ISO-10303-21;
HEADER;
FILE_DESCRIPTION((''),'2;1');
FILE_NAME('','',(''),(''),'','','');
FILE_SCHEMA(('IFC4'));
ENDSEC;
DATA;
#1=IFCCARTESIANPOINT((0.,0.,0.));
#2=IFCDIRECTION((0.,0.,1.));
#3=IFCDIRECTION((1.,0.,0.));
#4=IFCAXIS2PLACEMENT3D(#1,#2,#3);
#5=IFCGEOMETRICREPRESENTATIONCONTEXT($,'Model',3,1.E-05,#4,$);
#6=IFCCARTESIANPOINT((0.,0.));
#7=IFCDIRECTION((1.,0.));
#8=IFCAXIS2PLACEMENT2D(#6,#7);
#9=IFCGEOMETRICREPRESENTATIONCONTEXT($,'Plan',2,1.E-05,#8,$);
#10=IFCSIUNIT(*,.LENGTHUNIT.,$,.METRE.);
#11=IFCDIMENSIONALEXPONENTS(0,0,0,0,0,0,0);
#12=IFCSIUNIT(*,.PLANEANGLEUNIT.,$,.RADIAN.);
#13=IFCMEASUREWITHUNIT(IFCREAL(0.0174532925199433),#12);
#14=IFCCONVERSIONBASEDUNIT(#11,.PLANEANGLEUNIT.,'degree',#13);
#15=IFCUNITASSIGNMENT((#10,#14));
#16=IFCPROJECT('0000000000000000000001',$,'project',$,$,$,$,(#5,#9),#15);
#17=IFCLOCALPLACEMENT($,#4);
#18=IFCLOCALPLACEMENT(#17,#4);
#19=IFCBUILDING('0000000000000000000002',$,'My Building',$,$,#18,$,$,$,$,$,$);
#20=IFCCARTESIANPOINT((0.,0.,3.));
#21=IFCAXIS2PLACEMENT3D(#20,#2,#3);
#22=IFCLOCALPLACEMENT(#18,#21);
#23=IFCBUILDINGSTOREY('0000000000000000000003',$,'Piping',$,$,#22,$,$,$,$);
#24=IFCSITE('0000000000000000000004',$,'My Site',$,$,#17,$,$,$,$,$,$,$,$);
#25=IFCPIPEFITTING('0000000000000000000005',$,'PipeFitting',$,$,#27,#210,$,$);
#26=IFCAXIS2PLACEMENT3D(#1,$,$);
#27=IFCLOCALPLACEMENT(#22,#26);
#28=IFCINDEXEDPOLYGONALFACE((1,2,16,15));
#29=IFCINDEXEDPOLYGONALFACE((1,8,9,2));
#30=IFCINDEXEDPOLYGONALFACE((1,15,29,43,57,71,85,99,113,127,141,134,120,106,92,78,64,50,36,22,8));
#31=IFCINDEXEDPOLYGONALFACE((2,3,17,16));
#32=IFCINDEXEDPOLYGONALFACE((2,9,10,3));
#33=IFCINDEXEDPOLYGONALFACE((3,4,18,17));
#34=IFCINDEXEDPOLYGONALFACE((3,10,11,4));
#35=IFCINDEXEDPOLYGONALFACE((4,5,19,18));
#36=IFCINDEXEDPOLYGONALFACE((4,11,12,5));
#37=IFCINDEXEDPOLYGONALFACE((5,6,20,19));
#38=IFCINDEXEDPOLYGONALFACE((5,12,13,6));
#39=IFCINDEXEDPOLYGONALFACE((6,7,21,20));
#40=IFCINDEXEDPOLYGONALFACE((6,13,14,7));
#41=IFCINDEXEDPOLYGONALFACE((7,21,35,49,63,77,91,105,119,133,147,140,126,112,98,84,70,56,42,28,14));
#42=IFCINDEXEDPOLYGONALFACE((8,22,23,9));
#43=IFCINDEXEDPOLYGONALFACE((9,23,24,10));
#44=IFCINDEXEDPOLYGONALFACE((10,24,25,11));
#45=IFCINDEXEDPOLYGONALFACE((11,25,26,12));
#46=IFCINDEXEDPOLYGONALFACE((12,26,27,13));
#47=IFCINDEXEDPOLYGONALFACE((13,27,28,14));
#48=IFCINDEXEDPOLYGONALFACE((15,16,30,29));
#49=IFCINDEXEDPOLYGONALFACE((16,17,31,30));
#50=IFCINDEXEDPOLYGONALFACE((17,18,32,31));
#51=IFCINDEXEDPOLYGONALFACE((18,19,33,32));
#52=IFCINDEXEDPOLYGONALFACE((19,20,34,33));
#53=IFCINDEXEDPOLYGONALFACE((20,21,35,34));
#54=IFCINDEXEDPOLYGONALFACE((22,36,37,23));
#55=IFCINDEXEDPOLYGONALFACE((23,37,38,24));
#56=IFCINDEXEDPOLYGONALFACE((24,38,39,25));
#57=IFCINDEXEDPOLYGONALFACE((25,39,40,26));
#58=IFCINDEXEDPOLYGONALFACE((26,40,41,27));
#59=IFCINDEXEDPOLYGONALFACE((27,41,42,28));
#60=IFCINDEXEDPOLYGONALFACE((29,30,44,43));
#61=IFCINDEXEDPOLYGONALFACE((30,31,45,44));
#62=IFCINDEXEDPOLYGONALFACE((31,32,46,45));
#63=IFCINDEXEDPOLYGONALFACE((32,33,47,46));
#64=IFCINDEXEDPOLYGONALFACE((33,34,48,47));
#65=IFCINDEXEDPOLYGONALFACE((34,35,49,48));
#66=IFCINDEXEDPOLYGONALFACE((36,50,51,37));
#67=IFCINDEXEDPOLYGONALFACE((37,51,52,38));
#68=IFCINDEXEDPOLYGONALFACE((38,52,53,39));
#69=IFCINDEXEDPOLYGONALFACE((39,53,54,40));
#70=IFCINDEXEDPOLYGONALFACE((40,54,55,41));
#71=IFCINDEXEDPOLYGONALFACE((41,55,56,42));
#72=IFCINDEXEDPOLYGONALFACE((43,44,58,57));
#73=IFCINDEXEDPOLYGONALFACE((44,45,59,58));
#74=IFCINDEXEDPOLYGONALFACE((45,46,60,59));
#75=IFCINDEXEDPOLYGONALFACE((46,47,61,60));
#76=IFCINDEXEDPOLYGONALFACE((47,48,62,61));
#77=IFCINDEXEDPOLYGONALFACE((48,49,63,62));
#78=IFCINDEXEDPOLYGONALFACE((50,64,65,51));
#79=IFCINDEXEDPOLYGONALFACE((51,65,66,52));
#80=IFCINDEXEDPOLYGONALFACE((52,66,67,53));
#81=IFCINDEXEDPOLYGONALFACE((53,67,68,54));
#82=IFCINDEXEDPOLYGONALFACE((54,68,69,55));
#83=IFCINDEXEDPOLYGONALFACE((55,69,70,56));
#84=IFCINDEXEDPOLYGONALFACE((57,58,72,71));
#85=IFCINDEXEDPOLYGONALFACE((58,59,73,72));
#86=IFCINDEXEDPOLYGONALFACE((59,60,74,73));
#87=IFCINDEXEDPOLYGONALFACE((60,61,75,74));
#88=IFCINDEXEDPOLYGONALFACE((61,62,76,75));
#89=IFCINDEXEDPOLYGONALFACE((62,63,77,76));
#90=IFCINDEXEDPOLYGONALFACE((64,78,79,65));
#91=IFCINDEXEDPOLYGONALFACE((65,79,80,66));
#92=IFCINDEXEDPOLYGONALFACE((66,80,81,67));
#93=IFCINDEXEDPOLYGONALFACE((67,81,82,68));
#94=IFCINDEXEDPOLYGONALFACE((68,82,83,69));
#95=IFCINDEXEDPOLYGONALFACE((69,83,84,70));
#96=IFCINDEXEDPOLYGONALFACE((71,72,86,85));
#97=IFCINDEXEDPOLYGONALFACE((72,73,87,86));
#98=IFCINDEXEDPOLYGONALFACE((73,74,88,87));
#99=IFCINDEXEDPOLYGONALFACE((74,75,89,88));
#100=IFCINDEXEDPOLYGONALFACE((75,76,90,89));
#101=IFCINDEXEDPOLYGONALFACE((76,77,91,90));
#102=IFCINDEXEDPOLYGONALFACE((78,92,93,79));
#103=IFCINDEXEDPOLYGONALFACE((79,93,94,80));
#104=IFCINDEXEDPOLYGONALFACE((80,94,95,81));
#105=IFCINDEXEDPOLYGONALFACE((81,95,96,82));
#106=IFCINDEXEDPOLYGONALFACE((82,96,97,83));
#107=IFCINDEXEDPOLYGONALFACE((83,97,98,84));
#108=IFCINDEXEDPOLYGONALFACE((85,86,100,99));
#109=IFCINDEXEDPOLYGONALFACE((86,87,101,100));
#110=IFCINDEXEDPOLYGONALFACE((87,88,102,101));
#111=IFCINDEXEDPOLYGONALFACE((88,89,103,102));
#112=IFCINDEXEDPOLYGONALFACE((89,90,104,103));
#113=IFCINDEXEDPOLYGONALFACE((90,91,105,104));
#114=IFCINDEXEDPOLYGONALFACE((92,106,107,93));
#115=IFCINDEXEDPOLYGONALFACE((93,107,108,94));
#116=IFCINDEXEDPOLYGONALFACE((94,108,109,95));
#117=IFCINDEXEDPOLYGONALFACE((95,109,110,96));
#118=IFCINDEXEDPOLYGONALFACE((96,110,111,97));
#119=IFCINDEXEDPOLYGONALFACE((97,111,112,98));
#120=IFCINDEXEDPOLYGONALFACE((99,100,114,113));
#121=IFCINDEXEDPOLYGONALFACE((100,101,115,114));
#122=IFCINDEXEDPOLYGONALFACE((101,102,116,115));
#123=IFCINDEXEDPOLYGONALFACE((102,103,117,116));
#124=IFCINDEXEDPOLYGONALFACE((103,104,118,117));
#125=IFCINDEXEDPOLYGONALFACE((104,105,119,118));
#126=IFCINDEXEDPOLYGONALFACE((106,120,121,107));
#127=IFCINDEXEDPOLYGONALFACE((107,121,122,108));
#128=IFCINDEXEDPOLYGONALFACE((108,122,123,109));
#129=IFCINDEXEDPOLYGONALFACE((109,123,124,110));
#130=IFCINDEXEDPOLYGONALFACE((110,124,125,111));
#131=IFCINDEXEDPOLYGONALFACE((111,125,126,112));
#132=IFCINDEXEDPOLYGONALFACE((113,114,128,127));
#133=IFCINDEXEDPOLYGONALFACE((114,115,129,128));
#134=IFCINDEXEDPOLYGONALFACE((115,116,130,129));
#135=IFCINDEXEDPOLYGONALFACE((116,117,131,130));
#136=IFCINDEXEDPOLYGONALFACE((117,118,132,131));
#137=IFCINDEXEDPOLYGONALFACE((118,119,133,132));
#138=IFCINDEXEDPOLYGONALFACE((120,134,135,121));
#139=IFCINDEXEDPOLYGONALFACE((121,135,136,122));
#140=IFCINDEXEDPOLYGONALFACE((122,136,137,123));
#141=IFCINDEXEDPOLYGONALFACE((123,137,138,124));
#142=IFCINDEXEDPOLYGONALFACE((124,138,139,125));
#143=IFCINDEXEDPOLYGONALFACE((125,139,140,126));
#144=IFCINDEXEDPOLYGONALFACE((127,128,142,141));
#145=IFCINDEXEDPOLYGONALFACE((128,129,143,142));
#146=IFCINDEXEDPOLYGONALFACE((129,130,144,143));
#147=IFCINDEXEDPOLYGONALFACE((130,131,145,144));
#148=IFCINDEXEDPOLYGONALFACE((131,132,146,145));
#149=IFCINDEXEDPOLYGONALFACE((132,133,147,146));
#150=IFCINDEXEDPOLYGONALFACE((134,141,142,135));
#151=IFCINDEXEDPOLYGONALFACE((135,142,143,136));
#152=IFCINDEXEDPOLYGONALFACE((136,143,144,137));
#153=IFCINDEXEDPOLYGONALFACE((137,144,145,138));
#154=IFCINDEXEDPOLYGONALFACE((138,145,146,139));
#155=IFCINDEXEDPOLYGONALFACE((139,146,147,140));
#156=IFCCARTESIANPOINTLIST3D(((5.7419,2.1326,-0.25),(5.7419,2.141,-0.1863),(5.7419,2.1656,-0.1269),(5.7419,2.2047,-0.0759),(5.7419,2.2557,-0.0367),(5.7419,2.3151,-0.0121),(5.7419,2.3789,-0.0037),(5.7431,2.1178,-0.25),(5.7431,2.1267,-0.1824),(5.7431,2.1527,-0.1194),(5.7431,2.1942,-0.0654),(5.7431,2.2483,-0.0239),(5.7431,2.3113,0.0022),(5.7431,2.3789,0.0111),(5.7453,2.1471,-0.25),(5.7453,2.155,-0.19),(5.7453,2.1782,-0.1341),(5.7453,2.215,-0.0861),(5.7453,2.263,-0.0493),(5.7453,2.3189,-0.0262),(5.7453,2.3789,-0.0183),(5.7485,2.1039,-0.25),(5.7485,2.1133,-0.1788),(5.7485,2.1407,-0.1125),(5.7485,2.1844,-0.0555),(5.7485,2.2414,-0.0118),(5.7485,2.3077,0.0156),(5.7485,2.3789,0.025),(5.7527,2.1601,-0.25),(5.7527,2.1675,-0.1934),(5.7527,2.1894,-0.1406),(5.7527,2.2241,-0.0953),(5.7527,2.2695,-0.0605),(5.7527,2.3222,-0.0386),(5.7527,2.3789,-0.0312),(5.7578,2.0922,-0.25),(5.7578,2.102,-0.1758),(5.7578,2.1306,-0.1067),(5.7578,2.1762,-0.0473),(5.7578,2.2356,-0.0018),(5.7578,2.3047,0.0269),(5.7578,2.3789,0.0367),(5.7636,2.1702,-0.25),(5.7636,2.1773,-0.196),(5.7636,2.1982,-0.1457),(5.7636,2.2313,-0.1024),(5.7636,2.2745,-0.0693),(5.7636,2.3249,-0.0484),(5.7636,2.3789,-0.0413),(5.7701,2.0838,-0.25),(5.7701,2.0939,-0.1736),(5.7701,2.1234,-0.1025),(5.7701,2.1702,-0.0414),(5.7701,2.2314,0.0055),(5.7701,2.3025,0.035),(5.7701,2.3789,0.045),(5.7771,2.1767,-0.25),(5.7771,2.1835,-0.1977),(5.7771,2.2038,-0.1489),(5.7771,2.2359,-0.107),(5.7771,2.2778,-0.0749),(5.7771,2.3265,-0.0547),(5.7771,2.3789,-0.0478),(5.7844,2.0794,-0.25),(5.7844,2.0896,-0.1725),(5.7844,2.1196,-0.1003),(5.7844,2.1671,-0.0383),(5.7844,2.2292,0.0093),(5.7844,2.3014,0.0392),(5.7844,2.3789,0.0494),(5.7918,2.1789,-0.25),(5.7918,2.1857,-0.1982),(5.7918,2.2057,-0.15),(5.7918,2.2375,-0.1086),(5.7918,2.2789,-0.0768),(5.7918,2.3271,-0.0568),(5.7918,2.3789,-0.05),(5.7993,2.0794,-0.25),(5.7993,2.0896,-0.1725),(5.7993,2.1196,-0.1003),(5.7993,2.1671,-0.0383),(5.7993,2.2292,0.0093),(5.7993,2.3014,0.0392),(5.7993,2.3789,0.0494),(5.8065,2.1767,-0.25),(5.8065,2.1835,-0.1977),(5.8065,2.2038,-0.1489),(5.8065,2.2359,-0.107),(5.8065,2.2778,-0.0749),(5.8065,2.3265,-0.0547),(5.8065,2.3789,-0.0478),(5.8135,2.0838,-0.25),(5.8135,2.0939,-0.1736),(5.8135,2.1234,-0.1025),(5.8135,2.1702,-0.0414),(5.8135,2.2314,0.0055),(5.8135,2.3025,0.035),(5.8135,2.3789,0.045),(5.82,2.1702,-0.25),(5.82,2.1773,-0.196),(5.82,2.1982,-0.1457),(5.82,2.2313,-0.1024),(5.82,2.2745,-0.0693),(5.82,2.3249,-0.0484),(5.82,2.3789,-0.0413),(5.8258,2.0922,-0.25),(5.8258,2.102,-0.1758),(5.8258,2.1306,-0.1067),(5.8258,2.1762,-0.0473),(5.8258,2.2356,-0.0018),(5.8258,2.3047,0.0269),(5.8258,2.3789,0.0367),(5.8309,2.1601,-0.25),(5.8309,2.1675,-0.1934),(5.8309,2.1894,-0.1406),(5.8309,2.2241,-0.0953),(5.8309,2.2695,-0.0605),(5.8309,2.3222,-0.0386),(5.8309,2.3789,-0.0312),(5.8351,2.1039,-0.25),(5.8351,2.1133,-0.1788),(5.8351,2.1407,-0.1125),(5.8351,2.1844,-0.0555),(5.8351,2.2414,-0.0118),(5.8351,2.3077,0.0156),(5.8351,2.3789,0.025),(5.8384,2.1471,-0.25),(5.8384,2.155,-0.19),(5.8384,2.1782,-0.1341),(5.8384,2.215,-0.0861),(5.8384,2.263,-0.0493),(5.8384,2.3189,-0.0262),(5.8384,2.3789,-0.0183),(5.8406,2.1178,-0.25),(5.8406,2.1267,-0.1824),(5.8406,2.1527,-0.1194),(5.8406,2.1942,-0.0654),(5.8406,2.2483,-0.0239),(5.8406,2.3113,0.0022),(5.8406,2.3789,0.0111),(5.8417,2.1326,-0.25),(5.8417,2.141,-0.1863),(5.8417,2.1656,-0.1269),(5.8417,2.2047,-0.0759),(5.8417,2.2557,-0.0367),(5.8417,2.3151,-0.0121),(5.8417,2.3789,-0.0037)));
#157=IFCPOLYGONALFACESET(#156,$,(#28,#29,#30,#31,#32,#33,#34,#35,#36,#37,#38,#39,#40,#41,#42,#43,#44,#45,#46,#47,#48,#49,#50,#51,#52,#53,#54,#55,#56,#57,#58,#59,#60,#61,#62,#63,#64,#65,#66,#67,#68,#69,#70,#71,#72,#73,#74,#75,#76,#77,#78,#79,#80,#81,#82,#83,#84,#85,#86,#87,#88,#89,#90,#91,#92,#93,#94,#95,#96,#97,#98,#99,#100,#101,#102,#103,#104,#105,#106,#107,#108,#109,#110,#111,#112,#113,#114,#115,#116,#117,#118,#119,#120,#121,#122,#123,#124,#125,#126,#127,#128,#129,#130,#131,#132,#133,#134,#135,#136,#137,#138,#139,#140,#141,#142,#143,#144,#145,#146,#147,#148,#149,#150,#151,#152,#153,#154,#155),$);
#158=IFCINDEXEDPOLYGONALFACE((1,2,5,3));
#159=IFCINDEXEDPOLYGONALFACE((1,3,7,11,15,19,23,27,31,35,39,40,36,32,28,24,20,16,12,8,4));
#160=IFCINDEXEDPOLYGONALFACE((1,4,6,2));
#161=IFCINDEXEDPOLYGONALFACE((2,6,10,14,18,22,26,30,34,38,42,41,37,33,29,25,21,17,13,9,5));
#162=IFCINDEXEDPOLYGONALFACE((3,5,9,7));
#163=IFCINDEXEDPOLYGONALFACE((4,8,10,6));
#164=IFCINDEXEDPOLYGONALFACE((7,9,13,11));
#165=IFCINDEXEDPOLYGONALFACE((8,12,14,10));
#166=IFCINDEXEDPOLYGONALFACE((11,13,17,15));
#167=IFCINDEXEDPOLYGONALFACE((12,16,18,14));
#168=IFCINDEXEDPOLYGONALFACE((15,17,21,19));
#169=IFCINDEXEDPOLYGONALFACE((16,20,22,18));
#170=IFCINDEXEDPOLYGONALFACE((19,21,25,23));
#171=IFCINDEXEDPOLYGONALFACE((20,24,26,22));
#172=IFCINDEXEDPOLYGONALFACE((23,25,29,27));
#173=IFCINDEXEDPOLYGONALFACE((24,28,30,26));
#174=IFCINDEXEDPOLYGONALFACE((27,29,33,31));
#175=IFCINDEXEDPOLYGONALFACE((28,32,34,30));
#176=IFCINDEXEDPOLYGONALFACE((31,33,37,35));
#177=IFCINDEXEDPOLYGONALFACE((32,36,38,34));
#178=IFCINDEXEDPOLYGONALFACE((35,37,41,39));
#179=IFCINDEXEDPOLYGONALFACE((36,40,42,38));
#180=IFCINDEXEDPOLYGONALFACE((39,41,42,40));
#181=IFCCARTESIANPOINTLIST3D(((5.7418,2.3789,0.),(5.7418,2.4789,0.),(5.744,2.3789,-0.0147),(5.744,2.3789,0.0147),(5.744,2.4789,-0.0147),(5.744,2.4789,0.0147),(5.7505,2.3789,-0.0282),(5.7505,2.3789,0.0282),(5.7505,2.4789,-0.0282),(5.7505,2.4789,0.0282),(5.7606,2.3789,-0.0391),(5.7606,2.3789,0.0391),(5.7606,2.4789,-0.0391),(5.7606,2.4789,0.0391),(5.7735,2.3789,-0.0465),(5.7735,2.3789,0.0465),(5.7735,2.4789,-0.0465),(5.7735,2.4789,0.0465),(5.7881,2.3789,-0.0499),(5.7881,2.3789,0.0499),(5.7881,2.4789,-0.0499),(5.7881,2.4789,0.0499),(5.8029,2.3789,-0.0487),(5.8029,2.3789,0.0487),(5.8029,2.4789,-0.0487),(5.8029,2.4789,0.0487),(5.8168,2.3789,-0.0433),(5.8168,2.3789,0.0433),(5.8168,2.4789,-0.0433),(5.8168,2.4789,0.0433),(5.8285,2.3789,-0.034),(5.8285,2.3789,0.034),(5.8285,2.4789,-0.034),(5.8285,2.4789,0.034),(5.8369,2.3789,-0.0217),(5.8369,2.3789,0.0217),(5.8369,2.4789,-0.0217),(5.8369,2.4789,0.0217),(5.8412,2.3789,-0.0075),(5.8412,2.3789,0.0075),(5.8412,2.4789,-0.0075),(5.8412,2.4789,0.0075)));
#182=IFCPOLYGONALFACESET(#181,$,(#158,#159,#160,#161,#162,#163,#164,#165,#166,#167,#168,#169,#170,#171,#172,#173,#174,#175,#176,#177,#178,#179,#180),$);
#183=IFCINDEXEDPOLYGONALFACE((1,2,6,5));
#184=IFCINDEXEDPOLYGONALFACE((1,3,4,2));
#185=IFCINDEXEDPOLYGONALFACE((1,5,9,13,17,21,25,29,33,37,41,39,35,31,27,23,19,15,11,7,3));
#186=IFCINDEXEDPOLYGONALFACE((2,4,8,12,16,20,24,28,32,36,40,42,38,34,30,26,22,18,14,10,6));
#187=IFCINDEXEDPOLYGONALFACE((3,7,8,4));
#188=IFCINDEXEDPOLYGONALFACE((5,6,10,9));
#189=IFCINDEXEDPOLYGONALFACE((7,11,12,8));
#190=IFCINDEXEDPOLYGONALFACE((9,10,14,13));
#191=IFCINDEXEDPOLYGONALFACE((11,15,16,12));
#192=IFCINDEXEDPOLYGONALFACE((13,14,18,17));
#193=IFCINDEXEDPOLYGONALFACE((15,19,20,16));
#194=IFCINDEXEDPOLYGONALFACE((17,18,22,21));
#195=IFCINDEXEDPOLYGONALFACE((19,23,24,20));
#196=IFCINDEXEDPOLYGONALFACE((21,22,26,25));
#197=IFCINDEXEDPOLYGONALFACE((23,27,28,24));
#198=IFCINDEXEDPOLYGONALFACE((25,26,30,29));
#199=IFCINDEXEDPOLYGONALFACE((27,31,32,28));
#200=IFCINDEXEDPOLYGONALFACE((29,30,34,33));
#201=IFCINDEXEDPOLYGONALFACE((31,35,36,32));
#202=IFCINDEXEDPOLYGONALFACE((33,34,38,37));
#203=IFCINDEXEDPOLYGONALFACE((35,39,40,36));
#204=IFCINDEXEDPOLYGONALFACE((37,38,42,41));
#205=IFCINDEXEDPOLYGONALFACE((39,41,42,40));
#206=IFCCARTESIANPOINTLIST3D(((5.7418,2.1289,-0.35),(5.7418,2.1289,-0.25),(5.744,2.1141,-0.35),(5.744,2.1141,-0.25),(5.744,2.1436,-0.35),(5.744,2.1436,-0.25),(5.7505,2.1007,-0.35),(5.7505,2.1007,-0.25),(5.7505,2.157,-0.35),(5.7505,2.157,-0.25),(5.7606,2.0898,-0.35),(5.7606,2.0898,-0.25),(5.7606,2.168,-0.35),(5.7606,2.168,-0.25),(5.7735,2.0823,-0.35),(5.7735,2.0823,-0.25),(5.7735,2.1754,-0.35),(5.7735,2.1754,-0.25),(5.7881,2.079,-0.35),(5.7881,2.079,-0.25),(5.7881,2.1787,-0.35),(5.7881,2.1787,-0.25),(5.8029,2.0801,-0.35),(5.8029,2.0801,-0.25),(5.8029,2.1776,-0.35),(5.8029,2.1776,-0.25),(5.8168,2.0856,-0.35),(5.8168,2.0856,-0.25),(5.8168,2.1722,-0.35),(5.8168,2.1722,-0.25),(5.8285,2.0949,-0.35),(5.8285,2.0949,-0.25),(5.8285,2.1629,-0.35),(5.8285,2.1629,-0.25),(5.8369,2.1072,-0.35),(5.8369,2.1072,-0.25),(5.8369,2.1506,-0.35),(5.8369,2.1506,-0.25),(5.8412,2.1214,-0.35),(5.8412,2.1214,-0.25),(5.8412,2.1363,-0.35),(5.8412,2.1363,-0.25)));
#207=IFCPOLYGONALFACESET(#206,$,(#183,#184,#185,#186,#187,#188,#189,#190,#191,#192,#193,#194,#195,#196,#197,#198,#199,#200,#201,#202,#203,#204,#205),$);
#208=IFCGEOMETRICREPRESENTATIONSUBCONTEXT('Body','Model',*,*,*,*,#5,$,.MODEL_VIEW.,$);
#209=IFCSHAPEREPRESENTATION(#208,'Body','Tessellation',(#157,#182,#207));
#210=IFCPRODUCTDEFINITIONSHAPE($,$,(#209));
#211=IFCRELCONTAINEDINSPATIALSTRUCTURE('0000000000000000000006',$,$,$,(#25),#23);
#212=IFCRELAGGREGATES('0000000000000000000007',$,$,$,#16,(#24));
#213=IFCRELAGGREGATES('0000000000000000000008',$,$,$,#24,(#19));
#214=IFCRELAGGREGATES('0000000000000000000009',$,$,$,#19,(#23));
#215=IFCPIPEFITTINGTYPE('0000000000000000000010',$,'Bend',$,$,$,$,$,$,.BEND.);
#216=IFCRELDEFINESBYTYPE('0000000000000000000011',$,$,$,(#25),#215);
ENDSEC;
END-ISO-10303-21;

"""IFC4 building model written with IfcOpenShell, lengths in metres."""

from ifc_helpers import new_model, entity, si_unit, converted_unit, frame, origin_with_axes, origin_2d_with_axis, place, context, subcontext, project, spatial, circle, extrude, source, transform, mapped, type_object, type_shapes, element, save


model = new_model("IFC4")

# Units and contexts
model_context = context("Model", 3, precision=1e-05, world=origin_with_axes())
plan_context = context("Plan", 2, precision=1e-05, world=origin_2d_with_axis())
body_context = subcontext(model_context, "Body", "Model", "MODEL_VIEW")
ifc_project = project(units=[si_unit("LENGTHUNIT", "METRE"), converted_unit("PLANEANGLEUNIT", "degree", entity("IfcReal", 0.0174532925199433), si_unit("PLANEANGLEUNIT", "RADIAN"), dimensions=[0, 0, 0, 0, 0, 0, 0])], contexts=[model_context, plan_context])

# Site, building, storey
site_placement = place(None, origin_with_axes())
site = spatial("IfcSite", under=ifc_project, at=site_placement, Name="My Site")
building_placement = place(site_placement, origin_with_axes())
building = spatial("IfcBuilding", under=site, at=building_placement, Name="My Building")
storey_placement = place(building_placement, frame((0.0, 0.0, 3.0), z_axis=(0.0, 0.0, 1.0), x_axis=(1.0, 0.0, 0.0)))
storey = spatial("IfcBuildingStorey", under=building, at=storey_placement, Name="Piping")

# Pipe fitting
pipe_fitting_type = type_object("IfcPipeFittingType", Name="Bend", PredefinedType="BEND")
shared_shape = source(origin_with_axes(), body_context, "Body", "SolidModel", [
    entity("IfcSweptDiskSolid", entity("IfcIndexedPolyCurve", entity("IfcCartesianPointList3D", [[0.0, 0.0, -0.1], [0.0, -0.0732, -0.2768], [0.0, -0.25, -0.35]]), [entity("IfcArcIndex", [1, 2, 3])]), 0.05),
    extrude(circle(Radius=0.05), origin_with_axes(), (0.0, 0.0, -1.0), 0.1),
    extrude(circle(Radius=0.05), frame((0.0, -0.25, -0.35), z_axis=(0.0, -1.0, 0.0), x_axis=(1.0, 0.0, 0.0)), (0.0, 0.0, 1.0), 0.1),
])
type_shapes(pipe_fitting_type, [shared_shape])
for number, where, z_axis, x_axis, name in (
    (1, (5.7918, 2.4789, 0.0), (0.0, 1.0, 0.0), (-1.0, 0.0, 0.0), "PipeFitting"),
):
    element("IfcPipeFitting", number, at=place(storey_placement, frame(where, z_axis=z_axis, x_axis=x_axis)), inside=storey, type_object=pipe_fitting_type, Name=name, context=body_context, shape_type="MappedRepresentation", body=[
        mapped(shared_shape, transform((0.0, 0.0, 0.0), x_axis=(1.0, 0.0, 0.0), y_axis=(0.0, 1.0, 0.0), z_axis=(0.0, 0.0, 1.0), scale=1.0)),
    ])

save(model, "model.ifc")
